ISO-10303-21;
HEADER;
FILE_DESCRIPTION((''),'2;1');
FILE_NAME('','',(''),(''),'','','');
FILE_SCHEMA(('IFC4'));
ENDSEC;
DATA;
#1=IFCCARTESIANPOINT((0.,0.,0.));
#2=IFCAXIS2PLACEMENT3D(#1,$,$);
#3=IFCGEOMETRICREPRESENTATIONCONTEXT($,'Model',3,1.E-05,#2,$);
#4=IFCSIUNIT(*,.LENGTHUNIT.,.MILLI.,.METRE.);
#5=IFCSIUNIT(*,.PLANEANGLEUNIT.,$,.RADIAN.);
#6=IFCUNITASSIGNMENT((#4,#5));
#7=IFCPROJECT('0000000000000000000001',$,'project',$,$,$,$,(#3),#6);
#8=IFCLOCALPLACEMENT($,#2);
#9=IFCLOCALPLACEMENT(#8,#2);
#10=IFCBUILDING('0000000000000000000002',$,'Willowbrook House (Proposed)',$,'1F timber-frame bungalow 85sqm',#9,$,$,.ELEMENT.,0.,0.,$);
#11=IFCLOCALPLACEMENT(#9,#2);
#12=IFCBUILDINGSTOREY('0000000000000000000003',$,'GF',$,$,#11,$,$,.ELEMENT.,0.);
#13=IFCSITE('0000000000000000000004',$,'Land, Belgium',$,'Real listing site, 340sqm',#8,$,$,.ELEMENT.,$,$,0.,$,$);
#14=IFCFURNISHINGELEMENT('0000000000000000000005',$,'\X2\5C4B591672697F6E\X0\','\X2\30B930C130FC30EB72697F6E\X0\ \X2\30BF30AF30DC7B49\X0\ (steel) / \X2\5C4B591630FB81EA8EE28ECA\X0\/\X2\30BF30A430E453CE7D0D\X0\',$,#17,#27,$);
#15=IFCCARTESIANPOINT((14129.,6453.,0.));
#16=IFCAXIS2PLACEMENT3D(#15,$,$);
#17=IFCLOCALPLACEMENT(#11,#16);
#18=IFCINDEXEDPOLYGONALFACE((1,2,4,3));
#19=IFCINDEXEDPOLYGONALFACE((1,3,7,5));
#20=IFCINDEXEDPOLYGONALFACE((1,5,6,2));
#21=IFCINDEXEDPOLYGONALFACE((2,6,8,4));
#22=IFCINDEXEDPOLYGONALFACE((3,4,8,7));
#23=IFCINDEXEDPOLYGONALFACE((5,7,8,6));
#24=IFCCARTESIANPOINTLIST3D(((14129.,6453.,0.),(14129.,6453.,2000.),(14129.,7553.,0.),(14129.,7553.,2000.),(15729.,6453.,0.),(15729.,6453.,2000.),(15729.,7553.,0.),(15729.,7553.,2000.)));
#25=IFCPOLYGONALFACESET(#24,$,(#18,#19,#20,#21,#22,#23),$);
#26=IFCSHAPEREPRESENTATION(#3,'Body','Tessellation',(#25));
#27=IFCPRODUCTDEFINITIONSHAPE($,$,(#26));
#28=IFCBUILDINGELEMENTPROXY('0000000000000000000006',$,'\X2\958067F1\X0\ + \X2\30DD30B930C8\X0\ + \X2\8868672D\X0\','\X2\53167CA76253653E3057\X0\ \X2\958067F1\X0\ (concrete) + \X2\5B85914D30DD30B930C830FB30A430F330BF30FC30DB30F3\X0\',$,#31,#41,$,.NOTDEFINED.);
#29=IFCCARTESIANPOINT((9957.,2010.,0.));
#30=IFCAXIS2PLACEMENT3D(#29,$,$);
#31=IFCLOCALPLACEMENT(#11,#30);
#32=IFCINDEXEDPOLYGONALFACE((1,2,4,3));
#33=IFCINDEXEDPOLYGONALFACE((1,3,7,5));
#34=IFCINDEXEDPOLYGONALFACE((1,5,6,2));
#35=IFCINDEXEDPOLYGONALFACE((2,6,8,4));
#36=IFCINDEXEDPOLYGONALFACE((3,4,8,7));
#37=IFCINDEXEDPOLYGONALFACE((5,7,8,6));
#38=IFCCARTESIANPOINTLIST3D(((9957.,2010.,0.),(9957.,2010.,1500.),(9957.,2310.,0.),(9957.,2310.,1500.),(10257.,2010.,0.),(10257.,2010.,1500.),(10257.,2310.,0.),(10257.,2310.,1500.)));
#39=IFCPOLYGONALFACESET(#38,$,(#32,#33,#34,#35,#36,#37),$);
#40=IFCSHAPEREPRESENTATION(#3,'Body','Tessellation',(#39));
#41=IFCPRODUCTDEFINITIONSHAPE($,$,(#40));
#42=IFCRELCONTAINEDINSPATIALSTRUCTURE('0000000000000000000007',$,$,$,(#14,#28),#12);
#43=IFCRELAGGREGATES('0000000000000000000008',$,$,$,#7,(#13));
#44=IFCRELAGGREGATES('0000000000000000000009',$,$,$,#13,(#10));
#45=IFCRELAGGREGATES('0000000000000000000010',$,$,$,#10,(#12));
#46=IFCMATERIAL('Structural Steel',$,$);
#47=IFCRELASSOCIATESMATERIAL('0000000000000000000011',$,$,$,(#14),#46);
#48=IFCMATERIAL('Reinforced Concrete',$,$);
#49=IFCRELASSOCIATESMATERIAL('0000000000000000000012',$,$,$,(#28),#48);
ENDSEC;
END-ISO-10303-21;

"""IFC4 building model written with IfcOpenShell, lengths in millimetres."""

from ifc_helpers import new_model, si_unit, frame, frame_2d, origin, place, context, project, spatial, rectangle, extrude, material, element, save


model = new_model("IFC4")

# Units and contexts
model_context = context("Model", 3, precision=1e-05, world=origin())
ifc_project = project(units=[si_unit("LENGTHUNIT", "METRE", prefix="MILLI"), si_unit("PLANEANGLEUNIT", "RADIAN")], contexts=[model_context])

# Site, building, storey
site_placement = place(None, origin())
site = spatial("IfcSite", under=ifc_project, at=site_placement, Name="Land, Belgium", ObjectType="Real listing site, 340sqm", CompositionType="ELEMENT", RefElevation=0.0)
building_placement = place(site_placement, origin())
building = spatial("IfcBuilding", under=site, at=building_placement, Name="Willowbrook House (Proposed)", ObjectType="1F timber-frame bungalow 85sqm", CompositionType="ELEMENT", ElevationOfRefHeight=0.0, ElevationOfTerrain=0.0)
storey_placement = place(building_placement, origin())
storey = spatial("IfcBuildingStorey", under=building, at=storey_placement, Name="GF", CompositionType="ELEMENT", Elevation=0.0)

# Shared definitions
ifc_material_1 = material(Name="Reinforced Concrete")

# Shared definitions
ifc_material_2 = material(Name="Structural Steel")

# Furnishing element
furnishing_1_placement = place(storey_placement, frame((14129.0, 6453.0, 0.0)))
element("IfcFurnishingElement", 1, at=furnishing_1_placement, inside=storey, material=ifc_material_2, Name="屋外物置", Description="スチール物置 タクボ等 (steel) / 屋外・自転車/タイヤ収納", context=model_context, shape_type="SweptSolid", body=[
    extrude(rectangle(XDim=1600.0, YDim=1100.0, at=frame_2d((800.0, 550.0))), frame((14129.0, 6453.0, 0.0)), (0.0, 0.0, 1.0), 2000.0),
])

# Building element proxy
proxy_placement = place(storey_placement, frame((9957.0, 2010.0, 0.0)))
element("IfcBuildingElementProxy", 2, at=proxy_placement, inside=storey, material=ifc_material_1, Name="門柱 + ポスト + 表札", Description="化粧打放し 門柱 (concrete) + 宅配ポスト・インターホン", PredefinedType="NOTDEFINED", context=model_context, shape_type="SweptSolid", body=[
    extrude(rectangle(XDim=300.0, YDim=300.0, at=frame_2d((150.0, 150.0))), frame((9957.0, 2010.0, 0.0)), (0.0, 0.0, 1.0), 1500.0),
])

save(model, "model.ifc")
